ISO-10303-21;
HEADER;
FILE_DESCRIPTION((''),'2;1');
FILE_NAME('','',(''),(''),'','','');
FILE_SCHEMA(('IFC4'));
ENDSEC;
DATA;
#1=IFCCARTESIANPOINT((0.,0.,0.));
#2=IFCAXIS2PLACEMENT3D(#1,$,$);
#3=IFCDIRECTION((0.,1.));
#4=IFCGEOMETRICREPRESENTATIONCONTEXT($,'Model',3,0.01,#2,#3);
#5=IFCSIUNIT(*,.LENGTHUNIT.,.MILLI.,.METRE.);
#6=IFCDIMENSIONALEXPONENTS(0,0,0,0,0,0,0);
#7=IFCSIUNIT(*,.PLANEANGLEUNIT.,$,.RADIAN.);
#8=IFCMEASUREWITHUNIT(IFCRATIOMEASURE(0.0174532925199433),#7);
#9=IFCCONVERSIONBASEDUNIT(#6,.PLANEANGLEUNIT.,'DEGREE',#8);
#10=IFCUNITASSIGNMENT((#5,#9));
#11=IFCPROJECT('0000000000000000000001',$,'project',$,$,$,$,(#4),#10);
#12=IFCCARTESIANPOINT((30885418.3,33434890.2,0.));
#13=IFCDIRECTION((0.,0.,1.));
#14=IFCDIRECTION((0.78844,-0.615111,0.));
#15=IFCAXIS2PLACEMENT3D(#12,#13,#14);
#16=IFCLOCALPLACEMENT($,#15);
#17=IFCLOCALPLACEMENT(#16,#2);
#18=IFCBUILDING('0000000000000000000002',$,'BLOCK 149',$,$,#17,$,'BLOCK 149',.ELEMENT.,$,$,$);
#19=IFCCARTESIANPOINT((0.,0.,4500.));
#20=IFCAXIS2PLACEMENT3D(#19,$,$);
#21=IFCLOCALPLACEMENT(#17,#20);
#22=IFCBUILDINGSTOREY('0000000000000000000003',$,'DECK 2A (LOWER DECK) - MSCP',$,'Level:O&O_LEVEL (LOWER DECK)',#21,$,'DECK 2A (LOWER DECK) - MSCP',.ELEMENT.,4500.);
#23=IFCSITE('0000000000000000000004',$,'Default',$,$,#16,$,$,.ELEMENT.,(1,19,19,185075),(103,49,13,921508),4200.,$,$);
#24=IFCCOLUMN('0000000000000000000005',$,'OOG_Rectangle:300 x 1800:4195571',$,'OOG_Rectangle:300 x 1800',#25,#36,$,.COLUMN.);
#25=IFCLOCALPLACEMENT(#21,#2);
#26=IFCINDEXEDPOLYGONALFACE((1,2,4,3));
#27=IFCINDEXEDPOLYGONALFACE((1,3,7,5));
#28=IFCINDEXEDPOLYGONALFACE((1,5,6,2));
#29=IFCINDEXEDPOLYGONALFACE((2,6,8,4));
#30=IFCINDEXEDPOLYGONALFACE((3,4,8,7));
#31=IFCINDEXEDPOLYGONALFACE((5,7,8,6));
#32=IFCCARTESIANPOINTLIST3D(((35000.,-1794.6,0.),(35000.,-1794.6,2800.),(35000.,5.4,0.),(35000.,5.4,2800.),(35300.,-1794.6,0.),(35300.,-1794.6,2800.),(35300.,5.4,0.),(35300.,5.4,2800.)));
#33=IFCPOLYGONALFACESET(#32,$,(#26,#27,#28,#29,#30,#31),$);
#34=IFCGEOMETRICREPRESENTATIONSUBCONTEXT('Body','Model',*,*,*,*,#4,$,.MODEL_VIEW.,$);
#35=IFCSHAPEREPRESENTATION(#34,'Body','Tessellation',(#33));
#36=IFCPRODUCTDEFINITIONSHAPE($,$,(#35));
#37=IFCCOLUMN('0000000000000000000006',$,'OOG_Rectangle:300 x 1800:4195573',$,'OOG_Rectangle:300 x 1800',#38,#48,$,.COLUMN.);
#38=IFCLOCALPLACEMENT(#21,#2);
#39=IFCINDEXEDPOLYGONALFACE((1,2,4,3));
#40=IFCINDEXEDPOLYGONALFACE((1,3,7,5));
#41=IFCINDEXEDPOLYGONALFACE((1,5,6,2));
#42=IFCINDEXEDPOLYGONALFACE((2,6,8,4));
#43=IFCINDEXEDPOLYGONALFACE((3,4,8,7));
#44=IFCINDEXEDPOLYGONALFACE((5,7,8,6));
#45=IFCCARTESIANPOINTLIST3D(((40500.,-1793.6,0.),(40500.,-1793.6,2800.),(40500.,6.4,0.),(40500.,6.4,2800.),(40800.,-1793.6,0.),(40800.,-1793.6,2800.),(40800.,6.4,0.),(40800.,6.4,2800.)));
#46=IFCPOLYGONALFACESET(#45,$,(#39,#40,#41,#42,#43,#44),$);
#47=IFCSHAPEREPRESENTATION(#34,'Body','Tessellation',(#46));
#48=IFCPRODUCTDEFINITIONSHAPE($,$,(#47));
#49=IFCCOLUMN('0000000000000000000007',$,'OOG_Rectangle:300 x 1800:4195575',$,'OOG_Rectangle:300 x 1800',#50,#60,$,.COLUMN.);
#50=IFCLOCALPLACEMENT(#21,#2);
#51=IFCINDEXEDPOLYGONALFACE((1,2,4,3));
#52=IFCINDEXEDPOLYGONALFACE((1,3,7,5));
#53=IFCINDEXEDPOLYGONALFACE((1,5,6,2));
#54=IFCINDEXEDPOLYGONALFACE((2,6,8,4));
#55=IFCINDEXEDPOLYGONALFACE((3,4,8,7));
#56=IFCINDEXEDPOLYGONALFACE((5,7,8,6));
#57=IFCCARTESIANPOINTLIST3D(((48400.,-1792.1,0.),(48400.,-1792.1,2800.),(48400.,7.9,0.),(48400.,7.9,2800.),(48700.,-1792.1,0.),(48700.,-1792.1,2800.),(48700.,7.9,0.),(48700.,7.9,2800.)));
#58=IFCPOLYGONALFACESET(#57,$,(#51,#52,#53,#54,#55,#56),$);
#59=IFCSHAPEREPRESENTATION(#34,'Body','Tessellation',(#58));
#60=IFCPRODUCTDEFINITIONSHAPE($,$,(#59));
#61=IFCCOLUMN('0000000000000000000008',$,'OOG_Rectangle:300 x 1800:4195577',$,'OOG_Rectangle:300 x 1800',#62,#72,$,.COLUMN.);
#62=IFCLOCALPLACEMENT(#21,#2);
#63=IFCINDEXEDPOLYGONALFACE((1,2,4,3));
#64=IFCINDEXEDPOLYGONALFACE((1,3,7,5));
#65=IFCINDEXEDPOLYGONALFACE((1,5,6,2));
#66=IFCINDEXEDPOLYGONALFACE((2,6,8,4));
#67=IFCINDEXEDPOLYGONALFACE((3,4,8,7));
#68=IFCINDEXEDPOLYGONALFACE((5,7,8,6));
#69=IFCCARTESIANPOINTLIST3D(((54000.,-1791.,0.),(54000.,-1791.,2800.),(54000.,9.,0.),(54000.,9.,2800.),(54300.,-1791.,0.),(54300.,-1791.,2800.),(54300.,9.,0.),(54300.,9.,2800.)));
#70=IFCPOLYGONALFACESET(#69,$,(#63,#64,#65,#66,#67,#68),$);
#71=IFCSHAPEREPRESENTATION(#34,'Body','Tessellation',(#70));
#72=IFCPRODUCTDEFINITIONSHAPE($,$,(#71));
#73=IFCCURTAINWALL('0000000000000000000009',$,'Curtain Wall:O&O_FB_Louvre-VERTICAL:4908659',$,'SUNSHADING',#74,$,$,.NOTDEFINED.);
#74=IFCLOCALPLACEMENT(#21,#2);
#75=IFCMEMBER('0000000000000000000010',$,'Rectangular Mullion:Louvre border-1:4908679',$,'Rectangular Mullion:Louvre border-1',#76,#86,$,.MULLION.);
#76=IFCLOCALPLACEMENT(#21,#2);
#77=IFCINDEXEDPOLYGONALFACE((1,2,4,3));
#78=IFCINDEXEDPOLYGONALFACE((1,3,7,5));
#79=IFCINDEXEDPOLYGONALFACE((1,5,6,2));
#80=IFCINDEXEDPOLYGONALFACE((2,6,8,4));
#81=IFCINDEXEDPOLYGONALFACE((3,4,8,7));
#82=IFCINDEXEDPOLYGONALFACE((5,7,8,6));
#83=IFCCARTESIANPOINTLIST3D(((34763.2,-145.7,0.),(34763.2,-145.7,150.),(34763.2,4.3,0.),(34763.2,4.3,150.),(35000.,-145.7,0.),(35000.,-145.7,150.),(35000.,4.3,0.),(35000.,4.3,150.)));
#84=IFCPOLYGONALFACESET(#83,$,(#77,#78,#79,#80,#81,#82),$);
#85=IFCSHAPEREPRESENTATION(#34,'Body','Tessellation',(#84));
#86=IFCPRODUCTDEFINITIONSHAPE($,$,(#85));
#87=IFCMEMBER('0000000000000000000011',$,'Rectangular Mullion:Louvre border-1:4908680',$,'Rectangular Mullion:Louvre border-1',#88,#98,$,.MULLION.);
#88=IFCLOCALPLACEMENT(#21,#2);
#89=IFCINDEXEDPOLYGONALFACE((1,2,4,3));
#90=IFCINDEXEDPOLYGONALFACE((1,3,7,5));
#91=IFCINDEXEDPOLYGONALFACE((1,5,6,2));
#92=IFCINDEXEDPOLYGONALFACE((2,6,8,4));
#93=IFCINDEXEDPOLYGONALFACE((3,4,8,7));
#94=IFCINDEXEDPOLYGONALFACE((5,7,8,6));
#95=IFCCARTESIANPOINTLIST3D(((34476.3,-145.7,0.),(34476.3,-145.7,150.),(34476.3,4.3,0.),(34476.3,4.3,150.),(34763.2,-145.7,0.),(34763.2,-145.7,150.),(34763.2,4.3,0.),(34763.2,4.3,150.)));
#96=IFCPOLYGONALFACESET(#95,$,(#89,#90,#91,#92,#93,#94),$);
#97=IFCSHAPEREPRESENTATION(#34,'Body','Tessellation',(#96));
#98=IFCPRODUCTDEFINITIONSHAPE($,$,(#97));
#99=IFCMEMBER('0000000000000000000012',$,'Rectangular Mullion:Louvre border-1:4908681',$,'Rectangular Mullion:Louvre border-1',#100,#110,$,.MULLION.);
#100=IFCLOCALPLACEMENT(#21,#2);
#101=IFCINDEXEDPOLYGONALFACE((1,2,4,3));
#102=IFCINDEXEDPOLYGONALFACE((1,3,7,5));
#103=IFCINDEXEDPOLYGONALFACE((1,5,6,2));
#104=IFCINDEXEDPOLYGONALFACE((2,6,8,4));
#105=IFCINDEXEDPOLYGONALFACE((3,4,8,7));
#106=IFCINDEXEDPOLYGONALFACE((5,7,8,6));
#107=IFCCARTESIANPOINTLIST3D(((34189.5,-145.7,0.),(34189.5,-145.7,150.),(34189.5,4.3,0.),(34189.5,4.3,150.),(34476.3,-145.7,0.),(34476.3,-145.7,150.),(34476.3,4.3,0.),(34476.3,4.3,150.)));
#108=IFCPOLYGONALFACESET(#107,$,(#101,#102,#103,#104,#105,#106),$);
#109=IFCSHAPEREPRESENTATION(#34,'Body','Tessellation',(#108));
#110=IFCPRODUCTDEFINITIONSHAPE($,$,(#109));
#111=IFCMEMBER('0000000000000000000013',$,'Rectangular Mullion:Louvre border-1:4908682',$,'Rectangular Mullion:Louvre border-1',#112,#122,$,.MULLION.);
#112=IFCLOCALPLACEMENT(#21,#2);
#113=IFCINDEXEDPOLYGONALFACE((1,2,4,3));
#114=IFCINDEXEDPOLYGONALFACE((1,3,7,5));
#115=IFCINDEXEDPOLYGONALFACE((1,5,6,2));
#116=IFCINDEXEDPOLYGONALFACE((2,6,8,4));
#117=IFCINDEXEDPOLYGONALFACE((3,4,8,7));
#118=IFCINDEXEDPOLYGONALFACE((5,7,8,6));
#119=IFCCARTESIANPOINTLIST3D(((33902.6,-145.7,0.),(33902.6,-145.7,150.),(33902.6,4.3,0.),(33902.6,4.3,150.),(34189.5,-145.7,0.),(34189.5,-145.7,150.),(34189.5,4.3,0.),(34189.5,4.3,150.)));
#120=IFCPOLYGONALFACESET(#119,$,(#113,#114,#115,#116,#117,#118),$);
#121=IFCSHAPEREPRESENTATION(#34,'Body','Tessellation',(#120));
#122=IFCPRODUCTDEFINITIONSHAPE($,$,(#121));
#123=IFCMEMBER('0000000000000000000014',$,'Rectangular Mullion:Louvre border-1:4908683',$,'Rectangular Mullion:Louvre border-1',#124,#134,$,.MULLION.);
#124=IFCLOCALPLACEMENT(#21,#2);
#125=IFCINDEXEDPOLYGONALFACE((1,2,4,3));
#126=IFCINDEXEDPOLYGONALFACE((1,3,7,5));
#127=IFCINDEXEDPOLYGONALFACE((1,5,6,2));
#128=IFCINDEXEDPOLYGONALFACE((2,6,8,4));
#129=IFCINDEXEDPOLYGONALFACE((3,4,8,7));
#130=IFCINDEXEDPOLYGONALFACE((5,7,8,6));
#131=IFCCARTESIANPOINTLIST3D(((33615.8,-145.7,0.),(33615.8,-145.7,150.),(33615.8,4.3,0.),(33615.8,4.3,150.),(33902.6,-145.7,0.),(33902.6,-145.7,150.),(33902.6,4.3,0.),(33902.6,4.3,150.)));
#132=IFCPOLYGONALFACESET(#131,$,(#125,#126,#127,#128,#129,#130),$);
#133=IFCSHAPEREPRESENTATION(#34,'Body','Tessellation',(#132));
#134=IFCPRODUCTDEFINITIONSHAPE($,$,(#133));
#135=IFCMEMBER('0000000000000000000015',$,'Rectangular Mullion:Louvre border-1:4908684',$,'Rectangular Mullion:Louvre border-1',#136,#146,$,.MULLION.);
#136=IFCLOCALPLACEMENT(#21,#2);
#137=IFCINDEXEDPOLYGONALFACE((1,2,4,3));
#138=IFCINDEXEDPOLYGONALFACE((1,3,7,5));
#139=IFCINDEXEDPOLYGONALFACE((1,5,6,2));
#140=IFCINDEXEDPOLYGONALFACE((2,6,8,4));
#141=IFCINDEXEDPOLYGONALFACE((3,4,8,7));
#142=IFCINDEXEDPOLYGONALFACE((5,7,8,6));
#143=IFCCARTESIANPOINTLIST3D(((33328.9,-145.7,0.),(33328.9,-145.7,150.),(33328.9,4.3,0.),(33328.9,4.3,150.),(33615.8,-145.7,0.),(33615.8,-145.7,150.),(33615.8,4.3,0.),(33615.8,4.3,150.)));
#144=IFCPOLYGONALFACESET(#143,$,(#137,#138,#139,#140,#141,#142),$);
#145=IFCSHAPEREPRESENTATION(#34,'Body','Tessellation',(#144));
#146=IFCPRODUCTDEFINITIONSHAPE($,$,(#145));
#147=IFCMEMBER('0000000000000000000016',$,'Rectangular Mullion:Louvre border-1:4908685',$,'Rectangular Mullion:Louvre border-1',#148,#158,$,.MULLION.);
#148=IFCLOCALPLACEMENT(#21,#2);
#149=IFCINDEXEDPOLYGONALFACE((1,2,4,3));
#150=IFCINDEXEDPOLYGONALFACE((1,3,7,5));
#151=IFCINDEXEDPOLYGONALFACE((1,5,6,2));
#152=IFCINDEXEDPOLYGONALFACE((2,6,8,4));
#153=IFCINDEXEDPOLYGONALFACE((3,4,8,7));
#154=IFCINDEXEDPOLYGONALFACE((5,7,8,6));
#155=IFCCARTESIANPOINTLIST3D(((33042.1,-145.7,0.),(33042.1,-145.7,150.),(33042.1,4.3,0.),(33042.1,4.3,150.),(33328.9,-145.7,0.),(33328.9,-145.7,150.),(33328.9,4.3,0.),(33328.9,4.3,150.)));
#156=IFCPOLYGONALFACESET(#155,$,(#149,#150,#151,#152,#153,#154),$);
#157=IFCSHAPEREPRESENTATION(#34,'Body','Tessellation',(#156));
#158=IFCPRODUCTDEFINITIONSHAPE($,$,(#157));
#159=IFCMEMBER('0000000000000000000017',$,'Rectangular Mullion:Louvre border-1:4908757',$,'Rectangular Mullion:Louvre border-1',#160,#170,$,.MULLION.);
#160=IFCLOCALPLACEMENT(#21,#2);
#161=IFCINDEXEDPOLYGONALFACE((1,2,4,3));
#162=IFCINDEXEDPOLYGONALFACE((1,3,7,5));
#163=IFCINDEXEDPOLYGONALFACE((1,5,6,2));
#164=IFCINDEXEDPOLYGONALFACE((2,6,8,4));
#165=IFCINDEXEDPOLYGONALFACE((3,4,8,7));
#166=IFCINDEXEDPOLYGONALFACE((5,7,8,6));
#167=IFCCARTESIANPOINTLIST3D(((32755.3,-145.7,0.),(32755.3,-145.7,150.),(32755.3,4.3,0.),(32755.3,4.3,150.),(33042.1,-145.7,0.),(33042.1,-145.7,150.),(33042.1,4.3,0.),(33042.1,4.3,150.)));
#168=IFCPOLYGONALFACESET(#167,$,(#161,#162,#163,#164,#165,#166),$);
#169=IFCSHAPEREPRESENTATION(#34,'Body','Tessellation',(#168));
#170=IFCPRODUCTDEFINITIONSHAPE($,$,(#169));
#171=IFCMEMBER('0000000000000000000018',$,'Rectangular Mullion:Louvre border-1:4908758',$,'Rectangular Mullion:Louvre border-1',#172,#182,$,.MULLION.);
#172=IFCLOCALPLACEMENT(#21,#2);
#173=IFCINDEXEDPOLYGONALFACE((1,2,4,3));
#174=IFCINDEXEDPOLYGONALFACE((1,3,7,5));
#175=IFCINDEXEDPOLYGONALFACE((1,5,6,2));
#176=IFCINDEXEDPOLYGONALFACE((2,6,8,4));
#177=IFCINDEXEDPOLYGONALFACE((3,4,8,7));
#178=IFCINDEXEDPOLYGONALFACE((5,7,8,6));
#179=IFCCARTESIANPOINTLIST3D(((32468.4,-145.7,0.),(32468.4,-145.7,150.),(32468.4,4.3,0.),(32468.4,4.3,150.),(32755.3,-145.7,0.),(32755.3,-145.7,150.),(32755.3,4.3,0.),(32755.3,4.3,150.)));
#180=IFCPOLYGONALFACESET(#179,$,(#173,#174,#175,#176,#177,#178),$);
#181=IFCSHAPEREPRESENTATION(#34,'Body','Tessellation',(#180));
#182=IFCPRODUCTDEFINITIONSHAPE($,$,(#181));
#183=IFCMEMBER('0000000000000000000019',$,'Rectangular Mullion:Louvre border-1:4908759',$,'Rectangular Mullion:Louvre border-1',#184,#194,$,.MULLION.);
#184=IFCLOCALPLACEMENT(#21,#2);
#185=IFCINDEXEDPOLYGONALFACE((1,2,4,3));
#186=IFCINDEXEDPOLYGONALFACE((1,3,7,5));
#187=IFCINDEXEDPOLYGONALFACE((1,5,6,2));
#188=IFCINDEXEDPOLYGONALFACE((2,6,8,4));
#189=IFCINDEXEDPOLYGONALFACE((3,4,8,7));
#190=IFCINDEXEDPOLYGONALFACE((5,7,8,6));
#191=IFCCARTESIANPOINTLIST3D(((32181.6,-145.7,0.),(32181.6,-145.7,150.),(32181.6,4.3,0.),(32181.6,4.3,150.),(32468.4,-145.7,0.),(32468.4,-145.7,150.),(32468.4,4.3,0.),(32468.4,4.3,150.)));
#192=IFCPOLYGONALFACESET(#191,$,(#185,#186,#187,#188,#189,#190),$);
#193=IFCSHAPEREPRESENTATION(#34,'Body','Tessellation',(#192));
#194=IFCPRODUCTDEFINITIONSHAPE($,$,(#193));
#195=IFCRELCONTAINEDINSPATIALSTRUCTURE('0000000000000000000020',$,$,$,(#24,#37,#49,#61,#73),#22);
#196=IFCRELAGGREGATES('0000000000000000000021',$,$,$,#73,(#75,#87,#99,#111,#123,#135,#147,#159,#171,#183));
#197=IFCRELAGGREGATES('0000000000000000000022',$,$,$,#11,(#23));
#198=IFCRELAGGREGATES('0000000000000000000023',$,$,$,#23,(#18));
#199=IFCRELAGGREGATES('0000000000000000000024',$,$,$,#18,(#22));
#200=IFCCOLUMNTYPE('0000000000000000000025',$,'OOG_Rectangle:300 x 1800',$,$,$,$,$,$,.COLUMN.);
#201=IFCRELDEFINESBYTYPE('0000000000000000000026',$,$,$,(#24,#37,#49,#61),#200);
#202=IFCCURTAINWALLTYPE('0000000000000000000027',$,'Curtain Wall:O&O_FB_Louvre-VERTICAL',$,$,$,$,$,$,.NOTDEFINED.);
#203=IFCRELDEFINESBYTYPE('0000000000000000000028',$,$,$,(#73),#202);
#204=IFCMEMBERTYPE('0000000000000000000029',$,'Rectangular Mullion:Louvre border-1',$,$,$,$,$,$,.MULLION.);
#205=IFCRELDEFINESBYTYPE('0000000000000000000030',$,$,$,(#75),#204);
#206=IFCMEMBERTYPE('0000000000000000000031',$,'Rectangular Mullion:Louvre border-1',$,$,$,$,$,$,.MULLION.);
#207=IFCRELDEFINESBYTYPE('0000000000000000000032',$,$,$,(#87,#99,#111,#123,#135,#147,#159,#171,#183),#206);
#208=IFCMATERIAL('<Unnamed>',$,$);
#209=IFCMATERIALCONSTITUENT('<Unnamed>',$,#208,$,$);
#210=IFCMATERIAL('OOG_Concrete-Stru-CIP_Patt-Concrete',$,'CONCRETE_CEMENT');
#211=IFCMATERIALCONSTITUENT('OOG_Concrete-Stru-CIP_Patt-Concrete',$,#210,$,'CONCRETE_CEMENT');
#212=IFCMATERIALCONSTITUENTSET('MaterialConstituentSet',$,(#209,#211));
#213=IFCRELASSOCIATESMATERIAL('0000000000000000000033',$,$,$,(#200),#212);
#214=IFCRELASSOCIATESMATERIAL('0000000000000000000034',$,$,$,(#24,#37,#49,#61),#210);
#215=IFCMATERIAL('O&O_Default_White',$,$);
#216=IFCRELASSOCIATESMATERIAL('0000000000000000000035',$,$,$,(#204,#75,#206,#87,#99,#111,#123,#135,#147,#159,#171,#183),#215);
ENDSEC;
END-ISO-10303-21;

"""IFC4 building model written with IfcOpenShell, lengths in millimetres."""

from ifc_helpers import new_model, entity, si_unit, converted_unit, direction, frame, origin, place, context, subcontext, project, spatial, indexed_curve, outline, extrude, source, transform, mapped, material, constituent, constituent_set, type_object, type_shapes, element, aggregate, save


model = new_model("IFC4")

# Units and contexts
model_context = context("Model", 3, precision=0.01, world=origin(), true_north=direction((0.0, 1.0)))
body_context = subcontext(model_context, "Body", "Model", "MODEL_VIEW")
ifc_project = project(units=[si_unit("LENGTHUNIT", "METRE", prefix="MILLI"), converted_unit("PLANEANGLEUNIT", "DEGREE", entity("IfcRatioMeasure", 0.0174532925199433), si_unit("PLANEANGLEUNIT", "RADIAN"), dimensions=[0, 0, 0, 0, 0, 0, 0])], contexts=[model_context])

# Site, building, storey
site_placement = place(None, frame((30885418.3, 33434890.2, 0.0), z_axis=(0.0, 0.0, 1.0), x_axis=(0.78844, -0.615111, 0.0)))
site = spatial("IfcSite", under=ifc_project, at=site_placement, Name="Default", CompositionType="ELEMENT", RefLatitude=(1, 19, 19, 185075), RefLongitude=(103, 49, 13, 921508), RefElevation=4200.0)
building_placement = place(site_placement, origin())
building = spatial("IfcBuilding", under=site, at=building_placement, Name="BLOCK 149", LongName="BLOCK 149", CompositionType="ELEMENT")
storey_placement = place(building_placement, frame((0.0, 0.0, 4500.0)))
storey = spatial("IfcBuildingStorey", under=building, at=storey_placement, Name="DECK 2A (LOWER DECK) - MSCP", ObjectType="Level:O&O_LEVEL (LOWER DECK)", LongName="DECK 2A (LOWER DECK) - MSCP", CompositionType="ELEMENT", Elevation=4500.0)

# Columns
ifc_material_1 = material(Name="OOG_Concrete-Stru-CIP_Patt-Concrete", Category="CONCRETE_CEMENT")
ifc_material_2 = material(Name="<Unnamed>")
ifc_constituent_1 = constituent(ifc_material_2, Name="<Unnamed>")
ifc_constituent_2 = constituent(ifc_material_1, Name="OOG_Concrete-Stru-CIP_Patt-Concrete", Category="CONCRETE_CEMENT")
ifc_constituent_set_1 = constituent_set(constituents=[ifc_constituent_1, ifc_constituent_2], Name="MaterialConstituentSet")
column_type = type_object("IfcColumnType", Name="OOG_Rectangle:300 x 1800", PredefinedType="COLUMN", material=ifc_constituent_set_1)
shared_shape_1 = source(origin(), body_context, "Body", "SweptSolid", [
    extrude(outline(indexed_curve([(-900.0, -150.0), (900.0, -150.0), (900.0, 150.0), (-900.0, 150.0), (-900.0, -150.0)], self_intersect=False)), frame((0.0, 0.0, 4500.0), z_axis=(0.0, 0.0, 1.0), x_axis=(0.0, -1.0, 0.0)), (0.0, 0.0, 1.0), 2800.0),
])
type_shapes(column_type, [shared_shape_1])
for number, where, name in (
    (1, (35150.0, -894.6, -4500.0), "OOG_Rectangle:300 x 1800:4195571"),
    (2, (40650.0, -893.6, -4500.0), "OOG_Rectangle:300 x 1800:4195573"),
    (3, (48550.0, -892.1, -4500.0), "OOG_Rectangle:300 x 1800:4195575"),
    (4, (54150.0, -891.0, -4500.0), "OOG_Rectangle:300 x 1800:4195577"),
):
    element("IfcColumn", number, at=place(storey_placement, frame(where)), inside=storey, type_object=column_type, material=ifc_material_1, Name=name, ObjectType="OOG_Rectangle:300 x 1800", PredefinedType="COLUMN", context=body_context, shape_type="MappedRepresentation", body=[
        mapped(shared_shape_1, transform((0.0, 0.0, 0.0), scale=1.0)),
    ])

# Curtain wall, members
curtain_wall_type = type_object("IfcCurtainWallType", Name="Curtain Wall:O&O_FB_Louvre-VERTICAL", PredefinedType="NOTDEFINED")
curtain_wall_placement = place(storey_placement, frame((0.0, 0.0, -4500.0)))
curtain_wall = element("IfcCurtainWall", 5, at=curtain_wall_placement, inside=storey, type_object=curtain_wall_type, Name="Curtain Wall:O&O_FB_Louvre-VERTICAL:4908659", ObjectType="SUNSHADING", PredefinedType="NOTDEFINED")
ifc_material_3 = material(Name="O&O_Default_White")
member_type_1 = type_object("IfcMemberType", Name="Rectangular Mullion:Louvre border-1", PredefinedType="MULLION", material=ifc_material_3)
shared_shape_2 = source(origin(), body_context, "Body", "SweptSolid", [
    extrude(outline(indexed_curve([(-75.0, -75.0), (75.0, -75.0), (75.0, 75.0), (-75.0, 75.0), (-75.0, -75.0)], self_intersect=False)), frame((-75.0, 0.0, -236.8), z_axis=(0.0, 0.0, 1.0), x_axis=(0.0, -1.0, 0.0)), (0.0, 0.0, 1.0), 236.8),
])
type_shapes(member_type_1, [shared_shape_2])
placement = place(building_placement, origin())
member_1_placement = place(placement, frame((35000.0, -70.7, 4500.0), z_axis=(1.0, 0.0, 0.0), x_axis=(0.0, 0.0, -1.0)))
member_1 = element("IfcMember", 6, at=member_1_placement, type_object=member_type_1, material=ifc_material_3, Name="Rectangular Mullion:Louvre border-1:4908679", ObjectType="Rectangular Mullion:Louvre border-1", PredefinedType="MULLION", context=body_context, shape_type="MappedRepresentation", body=[
    mapped(shared_shape_2, transform((0.0, 0.0, 0.0), scale=1.0)),
])
member_type_2 = type_object("IfcMemberType", Name="Rectangular Mullion:Louvre border-1", PredefinedType="MULLION", material=ifc_material_3)
shared_shape_3 = source(origin(), body_context, "Body", "SweptSolid", [
    extrude(outline(indexed_curve([(-75.0, -75.0), (75.0, -75.0), (75.0, 75.0), (-75.0, 75.0), (-75.0, -75.0)], self_intersect=False)), frame((-75.0, 0.0, -286.8), z_axis=(0.0, 0.0, 1.0), x_axis=(0.0, -1.0, 0.0)), (0.0, 0.0, 1.0), 286.8),
])
type_shapes(member_type_2, [shared_shape_3])
member_2_placement = place(placement, frame((34763.2, -70.7, 4500.0), z_axis=(1.0, 0.0, 0.0), x_axis=(0.0, 0.0, -1.0)))
member_2 = element("IfcMember", 7, at=member_2_placement, type_object=member_type_2, material=ifc_material_3, Name="Rectangular Mullion:Louvre border-1:4908680", ObjectType="Rectangular Mullion:Louvre border-1", PredefinedType="MULLION", context=body_context, shape_type="MappedRepresentation", body=[
    mapped(shared_shape_3, transform((0.0, 0.0, 0.0), scale=1.0)),
])
member_3_placement = place(placement, frame((34476.3, -70.7, 4500.0), z_axis=(1.0, 0.0, 0.0), x_axis=(0.0, 0.0, -1.0)))
member_3 = element("IfcMember", 8, at=member_3_placement, type_object=member_type_2, material=ifc_material_3, Name="Rectangular Mullion:Louvre border-1:4908681", ObjectType="Rectangular Mullion:Louvre border-1", PredefinedType="MULLION", context=body_context, shape_type="MappedRepresentation", body=[
    mapped(shared_shape_3, transform((0.0, 0.0, 0.0), scale=1.0)),
])
member_4_placement = place(placement, frame((34189.5, -70.7, 4500.0), z_axis=(1.0, 0.0, 0.0), x_axis=(0.0, 0.0, -1.0)))
member_4 = element("IfcMember", 9, at=member_4_placement, type_object=member_type_2, material=ifc_material_3, Name="Rectangular Mullion:Louvre border-1:4908682", ObjectType="Rectangular Mullion:Louvre border-1", PredefinedType="MULLION", context=body_context, shape_type="MappedRepresentation", body=[
    mapped(shared_shape_3, transform((0.0, 0.0, 0.0), scale=1.0)),
])
member_5_placement = place(placement, frame((33902.6, -70.7, 4500.0), z_axis=(1.0, 0.0, 0.0), x_axis=(0.0, 0.0, -1.0)))
member_5 = element("IfcMember", 10, at=member_5_placement, type_object=member_type_2, material=ifc_material_3, Name="Rectangular Mullion:Louvre border-1:4908683", ObjectType="Rectangular Mullion:Louvre border-1", PredefinedType="MULLION", context=body_context, shape_type="MappedRepresentation", body=[
    mapped(shared_shape_3, transform((0.0, 0.0, 0.0), scale=1.0)),
])
member_6_placement = place(placement, frame((33615.8, -70.7, 4500.0), z_axis=(1.0, 0.0, 0.0), x_axis=(0.0, 0.0, -1.0)))
member_6 = element("IfcMember", 11, at=member_6_placement, type_object=member_type_2, material=ifc_material_3, Name="Rectangular Mullion:Louvre border-1:4908684", ObjectType="Rectangular Mullion:Louvre border-1", PredefinedType="MULLION", context=body_context, shape_type="MappedRepresentation", body=[
    mapped(shared_shape_3, transform((0.0, 0.0, 0.0), scale=1.0)),
])
member_7_placement = place(placement, frame((33328.9, -70.7, 4500.0), z_axis=(1.0, 0.0, 0.0), x_axis=(0.0, 0.0, -1.0)))
member_7 = element("IfcMember", 12, at=member_7_placement, type_object=member_type_2, material=ifc_material_3, Name="Rectangular Mullion:Louvre border-1:4908685", ObjectType="Rectangular Mullion:Louvre border-1", PredefinedType="MULLION", context=body_context, shape_type="MappedRepresentation", body=[
    mapped(shared_shape_3, transform((0.0, 0.0, 0.0), scale=1.0)),
])
member_8_placement = place(placement, frame((33042.1, -70.7, 4500.0), z_axis=(1.0, 0.0, 0.0), x_axis=(0.0, 0.0, -1.0)))
member_8 = element("IfcMember", 13, at=member_8_placement, type_object=member_type_2, material=ifc_material_3, Name="Rectangular Mullion:Louvre border-1:4908757", ObjectType="Rectangular Mullion:Louvre border-1", PredefinedType="MULLION", context=body_context, shape_type="MappedRepresentation", body=[
    mapped(shared_shape_3, transform((0.0, 0.0, 0.0), scale=1.0)),
])
member_9_placement = place(placement, frame((32755.3, -70.7, 4500.0), z_axis=(1.0, 0.0, 0.0), x_axis=(0.0, 0.0, -1.0)))
member_9 = element("IfcMember", 14, at=member_9_placement, type_object=member_type_2, material=ifc_material_3, Name="Rectangular Mullion:Louvre border-1:4908758", ObjectType="Rectangular Mullion:Louvre border-1", PredefinedType="MULLION", context=body_context, shape_type="MappedRepresentation", body=[
    mapped(shared_shape_3, transform((0.0, 0.0, 0.0), scale=1.0)),
])
member_10_placement = place(placement, frame((32468.4, -70.7, 4500.0), z_axis=(1.0, 0.0, 0.0), x_axis=(0.0, 0.0, -1.0)))
member_10 = element("IfcMember", 15, at=member_10_placement, type_object=member_type_2, material=ifc_material_3, Name="Rectangular Mullion:Louvre border-1:4908759", ObjectType="Rectangular Mullion:Louvre border-1", PredefinedType="MULLION", context=body_context, shape_type="MappedRepresentation", body=[
    mapped(shared_shape_3, transform((0.0, 0.0, 0.0), scale=1.0)),
])
aggregate(curtain_wall, [member_1, member_2, member_3, member_4, member_5, member_6, member_7, member_8, member_9, member_10])

save(model, "model.ifc")
